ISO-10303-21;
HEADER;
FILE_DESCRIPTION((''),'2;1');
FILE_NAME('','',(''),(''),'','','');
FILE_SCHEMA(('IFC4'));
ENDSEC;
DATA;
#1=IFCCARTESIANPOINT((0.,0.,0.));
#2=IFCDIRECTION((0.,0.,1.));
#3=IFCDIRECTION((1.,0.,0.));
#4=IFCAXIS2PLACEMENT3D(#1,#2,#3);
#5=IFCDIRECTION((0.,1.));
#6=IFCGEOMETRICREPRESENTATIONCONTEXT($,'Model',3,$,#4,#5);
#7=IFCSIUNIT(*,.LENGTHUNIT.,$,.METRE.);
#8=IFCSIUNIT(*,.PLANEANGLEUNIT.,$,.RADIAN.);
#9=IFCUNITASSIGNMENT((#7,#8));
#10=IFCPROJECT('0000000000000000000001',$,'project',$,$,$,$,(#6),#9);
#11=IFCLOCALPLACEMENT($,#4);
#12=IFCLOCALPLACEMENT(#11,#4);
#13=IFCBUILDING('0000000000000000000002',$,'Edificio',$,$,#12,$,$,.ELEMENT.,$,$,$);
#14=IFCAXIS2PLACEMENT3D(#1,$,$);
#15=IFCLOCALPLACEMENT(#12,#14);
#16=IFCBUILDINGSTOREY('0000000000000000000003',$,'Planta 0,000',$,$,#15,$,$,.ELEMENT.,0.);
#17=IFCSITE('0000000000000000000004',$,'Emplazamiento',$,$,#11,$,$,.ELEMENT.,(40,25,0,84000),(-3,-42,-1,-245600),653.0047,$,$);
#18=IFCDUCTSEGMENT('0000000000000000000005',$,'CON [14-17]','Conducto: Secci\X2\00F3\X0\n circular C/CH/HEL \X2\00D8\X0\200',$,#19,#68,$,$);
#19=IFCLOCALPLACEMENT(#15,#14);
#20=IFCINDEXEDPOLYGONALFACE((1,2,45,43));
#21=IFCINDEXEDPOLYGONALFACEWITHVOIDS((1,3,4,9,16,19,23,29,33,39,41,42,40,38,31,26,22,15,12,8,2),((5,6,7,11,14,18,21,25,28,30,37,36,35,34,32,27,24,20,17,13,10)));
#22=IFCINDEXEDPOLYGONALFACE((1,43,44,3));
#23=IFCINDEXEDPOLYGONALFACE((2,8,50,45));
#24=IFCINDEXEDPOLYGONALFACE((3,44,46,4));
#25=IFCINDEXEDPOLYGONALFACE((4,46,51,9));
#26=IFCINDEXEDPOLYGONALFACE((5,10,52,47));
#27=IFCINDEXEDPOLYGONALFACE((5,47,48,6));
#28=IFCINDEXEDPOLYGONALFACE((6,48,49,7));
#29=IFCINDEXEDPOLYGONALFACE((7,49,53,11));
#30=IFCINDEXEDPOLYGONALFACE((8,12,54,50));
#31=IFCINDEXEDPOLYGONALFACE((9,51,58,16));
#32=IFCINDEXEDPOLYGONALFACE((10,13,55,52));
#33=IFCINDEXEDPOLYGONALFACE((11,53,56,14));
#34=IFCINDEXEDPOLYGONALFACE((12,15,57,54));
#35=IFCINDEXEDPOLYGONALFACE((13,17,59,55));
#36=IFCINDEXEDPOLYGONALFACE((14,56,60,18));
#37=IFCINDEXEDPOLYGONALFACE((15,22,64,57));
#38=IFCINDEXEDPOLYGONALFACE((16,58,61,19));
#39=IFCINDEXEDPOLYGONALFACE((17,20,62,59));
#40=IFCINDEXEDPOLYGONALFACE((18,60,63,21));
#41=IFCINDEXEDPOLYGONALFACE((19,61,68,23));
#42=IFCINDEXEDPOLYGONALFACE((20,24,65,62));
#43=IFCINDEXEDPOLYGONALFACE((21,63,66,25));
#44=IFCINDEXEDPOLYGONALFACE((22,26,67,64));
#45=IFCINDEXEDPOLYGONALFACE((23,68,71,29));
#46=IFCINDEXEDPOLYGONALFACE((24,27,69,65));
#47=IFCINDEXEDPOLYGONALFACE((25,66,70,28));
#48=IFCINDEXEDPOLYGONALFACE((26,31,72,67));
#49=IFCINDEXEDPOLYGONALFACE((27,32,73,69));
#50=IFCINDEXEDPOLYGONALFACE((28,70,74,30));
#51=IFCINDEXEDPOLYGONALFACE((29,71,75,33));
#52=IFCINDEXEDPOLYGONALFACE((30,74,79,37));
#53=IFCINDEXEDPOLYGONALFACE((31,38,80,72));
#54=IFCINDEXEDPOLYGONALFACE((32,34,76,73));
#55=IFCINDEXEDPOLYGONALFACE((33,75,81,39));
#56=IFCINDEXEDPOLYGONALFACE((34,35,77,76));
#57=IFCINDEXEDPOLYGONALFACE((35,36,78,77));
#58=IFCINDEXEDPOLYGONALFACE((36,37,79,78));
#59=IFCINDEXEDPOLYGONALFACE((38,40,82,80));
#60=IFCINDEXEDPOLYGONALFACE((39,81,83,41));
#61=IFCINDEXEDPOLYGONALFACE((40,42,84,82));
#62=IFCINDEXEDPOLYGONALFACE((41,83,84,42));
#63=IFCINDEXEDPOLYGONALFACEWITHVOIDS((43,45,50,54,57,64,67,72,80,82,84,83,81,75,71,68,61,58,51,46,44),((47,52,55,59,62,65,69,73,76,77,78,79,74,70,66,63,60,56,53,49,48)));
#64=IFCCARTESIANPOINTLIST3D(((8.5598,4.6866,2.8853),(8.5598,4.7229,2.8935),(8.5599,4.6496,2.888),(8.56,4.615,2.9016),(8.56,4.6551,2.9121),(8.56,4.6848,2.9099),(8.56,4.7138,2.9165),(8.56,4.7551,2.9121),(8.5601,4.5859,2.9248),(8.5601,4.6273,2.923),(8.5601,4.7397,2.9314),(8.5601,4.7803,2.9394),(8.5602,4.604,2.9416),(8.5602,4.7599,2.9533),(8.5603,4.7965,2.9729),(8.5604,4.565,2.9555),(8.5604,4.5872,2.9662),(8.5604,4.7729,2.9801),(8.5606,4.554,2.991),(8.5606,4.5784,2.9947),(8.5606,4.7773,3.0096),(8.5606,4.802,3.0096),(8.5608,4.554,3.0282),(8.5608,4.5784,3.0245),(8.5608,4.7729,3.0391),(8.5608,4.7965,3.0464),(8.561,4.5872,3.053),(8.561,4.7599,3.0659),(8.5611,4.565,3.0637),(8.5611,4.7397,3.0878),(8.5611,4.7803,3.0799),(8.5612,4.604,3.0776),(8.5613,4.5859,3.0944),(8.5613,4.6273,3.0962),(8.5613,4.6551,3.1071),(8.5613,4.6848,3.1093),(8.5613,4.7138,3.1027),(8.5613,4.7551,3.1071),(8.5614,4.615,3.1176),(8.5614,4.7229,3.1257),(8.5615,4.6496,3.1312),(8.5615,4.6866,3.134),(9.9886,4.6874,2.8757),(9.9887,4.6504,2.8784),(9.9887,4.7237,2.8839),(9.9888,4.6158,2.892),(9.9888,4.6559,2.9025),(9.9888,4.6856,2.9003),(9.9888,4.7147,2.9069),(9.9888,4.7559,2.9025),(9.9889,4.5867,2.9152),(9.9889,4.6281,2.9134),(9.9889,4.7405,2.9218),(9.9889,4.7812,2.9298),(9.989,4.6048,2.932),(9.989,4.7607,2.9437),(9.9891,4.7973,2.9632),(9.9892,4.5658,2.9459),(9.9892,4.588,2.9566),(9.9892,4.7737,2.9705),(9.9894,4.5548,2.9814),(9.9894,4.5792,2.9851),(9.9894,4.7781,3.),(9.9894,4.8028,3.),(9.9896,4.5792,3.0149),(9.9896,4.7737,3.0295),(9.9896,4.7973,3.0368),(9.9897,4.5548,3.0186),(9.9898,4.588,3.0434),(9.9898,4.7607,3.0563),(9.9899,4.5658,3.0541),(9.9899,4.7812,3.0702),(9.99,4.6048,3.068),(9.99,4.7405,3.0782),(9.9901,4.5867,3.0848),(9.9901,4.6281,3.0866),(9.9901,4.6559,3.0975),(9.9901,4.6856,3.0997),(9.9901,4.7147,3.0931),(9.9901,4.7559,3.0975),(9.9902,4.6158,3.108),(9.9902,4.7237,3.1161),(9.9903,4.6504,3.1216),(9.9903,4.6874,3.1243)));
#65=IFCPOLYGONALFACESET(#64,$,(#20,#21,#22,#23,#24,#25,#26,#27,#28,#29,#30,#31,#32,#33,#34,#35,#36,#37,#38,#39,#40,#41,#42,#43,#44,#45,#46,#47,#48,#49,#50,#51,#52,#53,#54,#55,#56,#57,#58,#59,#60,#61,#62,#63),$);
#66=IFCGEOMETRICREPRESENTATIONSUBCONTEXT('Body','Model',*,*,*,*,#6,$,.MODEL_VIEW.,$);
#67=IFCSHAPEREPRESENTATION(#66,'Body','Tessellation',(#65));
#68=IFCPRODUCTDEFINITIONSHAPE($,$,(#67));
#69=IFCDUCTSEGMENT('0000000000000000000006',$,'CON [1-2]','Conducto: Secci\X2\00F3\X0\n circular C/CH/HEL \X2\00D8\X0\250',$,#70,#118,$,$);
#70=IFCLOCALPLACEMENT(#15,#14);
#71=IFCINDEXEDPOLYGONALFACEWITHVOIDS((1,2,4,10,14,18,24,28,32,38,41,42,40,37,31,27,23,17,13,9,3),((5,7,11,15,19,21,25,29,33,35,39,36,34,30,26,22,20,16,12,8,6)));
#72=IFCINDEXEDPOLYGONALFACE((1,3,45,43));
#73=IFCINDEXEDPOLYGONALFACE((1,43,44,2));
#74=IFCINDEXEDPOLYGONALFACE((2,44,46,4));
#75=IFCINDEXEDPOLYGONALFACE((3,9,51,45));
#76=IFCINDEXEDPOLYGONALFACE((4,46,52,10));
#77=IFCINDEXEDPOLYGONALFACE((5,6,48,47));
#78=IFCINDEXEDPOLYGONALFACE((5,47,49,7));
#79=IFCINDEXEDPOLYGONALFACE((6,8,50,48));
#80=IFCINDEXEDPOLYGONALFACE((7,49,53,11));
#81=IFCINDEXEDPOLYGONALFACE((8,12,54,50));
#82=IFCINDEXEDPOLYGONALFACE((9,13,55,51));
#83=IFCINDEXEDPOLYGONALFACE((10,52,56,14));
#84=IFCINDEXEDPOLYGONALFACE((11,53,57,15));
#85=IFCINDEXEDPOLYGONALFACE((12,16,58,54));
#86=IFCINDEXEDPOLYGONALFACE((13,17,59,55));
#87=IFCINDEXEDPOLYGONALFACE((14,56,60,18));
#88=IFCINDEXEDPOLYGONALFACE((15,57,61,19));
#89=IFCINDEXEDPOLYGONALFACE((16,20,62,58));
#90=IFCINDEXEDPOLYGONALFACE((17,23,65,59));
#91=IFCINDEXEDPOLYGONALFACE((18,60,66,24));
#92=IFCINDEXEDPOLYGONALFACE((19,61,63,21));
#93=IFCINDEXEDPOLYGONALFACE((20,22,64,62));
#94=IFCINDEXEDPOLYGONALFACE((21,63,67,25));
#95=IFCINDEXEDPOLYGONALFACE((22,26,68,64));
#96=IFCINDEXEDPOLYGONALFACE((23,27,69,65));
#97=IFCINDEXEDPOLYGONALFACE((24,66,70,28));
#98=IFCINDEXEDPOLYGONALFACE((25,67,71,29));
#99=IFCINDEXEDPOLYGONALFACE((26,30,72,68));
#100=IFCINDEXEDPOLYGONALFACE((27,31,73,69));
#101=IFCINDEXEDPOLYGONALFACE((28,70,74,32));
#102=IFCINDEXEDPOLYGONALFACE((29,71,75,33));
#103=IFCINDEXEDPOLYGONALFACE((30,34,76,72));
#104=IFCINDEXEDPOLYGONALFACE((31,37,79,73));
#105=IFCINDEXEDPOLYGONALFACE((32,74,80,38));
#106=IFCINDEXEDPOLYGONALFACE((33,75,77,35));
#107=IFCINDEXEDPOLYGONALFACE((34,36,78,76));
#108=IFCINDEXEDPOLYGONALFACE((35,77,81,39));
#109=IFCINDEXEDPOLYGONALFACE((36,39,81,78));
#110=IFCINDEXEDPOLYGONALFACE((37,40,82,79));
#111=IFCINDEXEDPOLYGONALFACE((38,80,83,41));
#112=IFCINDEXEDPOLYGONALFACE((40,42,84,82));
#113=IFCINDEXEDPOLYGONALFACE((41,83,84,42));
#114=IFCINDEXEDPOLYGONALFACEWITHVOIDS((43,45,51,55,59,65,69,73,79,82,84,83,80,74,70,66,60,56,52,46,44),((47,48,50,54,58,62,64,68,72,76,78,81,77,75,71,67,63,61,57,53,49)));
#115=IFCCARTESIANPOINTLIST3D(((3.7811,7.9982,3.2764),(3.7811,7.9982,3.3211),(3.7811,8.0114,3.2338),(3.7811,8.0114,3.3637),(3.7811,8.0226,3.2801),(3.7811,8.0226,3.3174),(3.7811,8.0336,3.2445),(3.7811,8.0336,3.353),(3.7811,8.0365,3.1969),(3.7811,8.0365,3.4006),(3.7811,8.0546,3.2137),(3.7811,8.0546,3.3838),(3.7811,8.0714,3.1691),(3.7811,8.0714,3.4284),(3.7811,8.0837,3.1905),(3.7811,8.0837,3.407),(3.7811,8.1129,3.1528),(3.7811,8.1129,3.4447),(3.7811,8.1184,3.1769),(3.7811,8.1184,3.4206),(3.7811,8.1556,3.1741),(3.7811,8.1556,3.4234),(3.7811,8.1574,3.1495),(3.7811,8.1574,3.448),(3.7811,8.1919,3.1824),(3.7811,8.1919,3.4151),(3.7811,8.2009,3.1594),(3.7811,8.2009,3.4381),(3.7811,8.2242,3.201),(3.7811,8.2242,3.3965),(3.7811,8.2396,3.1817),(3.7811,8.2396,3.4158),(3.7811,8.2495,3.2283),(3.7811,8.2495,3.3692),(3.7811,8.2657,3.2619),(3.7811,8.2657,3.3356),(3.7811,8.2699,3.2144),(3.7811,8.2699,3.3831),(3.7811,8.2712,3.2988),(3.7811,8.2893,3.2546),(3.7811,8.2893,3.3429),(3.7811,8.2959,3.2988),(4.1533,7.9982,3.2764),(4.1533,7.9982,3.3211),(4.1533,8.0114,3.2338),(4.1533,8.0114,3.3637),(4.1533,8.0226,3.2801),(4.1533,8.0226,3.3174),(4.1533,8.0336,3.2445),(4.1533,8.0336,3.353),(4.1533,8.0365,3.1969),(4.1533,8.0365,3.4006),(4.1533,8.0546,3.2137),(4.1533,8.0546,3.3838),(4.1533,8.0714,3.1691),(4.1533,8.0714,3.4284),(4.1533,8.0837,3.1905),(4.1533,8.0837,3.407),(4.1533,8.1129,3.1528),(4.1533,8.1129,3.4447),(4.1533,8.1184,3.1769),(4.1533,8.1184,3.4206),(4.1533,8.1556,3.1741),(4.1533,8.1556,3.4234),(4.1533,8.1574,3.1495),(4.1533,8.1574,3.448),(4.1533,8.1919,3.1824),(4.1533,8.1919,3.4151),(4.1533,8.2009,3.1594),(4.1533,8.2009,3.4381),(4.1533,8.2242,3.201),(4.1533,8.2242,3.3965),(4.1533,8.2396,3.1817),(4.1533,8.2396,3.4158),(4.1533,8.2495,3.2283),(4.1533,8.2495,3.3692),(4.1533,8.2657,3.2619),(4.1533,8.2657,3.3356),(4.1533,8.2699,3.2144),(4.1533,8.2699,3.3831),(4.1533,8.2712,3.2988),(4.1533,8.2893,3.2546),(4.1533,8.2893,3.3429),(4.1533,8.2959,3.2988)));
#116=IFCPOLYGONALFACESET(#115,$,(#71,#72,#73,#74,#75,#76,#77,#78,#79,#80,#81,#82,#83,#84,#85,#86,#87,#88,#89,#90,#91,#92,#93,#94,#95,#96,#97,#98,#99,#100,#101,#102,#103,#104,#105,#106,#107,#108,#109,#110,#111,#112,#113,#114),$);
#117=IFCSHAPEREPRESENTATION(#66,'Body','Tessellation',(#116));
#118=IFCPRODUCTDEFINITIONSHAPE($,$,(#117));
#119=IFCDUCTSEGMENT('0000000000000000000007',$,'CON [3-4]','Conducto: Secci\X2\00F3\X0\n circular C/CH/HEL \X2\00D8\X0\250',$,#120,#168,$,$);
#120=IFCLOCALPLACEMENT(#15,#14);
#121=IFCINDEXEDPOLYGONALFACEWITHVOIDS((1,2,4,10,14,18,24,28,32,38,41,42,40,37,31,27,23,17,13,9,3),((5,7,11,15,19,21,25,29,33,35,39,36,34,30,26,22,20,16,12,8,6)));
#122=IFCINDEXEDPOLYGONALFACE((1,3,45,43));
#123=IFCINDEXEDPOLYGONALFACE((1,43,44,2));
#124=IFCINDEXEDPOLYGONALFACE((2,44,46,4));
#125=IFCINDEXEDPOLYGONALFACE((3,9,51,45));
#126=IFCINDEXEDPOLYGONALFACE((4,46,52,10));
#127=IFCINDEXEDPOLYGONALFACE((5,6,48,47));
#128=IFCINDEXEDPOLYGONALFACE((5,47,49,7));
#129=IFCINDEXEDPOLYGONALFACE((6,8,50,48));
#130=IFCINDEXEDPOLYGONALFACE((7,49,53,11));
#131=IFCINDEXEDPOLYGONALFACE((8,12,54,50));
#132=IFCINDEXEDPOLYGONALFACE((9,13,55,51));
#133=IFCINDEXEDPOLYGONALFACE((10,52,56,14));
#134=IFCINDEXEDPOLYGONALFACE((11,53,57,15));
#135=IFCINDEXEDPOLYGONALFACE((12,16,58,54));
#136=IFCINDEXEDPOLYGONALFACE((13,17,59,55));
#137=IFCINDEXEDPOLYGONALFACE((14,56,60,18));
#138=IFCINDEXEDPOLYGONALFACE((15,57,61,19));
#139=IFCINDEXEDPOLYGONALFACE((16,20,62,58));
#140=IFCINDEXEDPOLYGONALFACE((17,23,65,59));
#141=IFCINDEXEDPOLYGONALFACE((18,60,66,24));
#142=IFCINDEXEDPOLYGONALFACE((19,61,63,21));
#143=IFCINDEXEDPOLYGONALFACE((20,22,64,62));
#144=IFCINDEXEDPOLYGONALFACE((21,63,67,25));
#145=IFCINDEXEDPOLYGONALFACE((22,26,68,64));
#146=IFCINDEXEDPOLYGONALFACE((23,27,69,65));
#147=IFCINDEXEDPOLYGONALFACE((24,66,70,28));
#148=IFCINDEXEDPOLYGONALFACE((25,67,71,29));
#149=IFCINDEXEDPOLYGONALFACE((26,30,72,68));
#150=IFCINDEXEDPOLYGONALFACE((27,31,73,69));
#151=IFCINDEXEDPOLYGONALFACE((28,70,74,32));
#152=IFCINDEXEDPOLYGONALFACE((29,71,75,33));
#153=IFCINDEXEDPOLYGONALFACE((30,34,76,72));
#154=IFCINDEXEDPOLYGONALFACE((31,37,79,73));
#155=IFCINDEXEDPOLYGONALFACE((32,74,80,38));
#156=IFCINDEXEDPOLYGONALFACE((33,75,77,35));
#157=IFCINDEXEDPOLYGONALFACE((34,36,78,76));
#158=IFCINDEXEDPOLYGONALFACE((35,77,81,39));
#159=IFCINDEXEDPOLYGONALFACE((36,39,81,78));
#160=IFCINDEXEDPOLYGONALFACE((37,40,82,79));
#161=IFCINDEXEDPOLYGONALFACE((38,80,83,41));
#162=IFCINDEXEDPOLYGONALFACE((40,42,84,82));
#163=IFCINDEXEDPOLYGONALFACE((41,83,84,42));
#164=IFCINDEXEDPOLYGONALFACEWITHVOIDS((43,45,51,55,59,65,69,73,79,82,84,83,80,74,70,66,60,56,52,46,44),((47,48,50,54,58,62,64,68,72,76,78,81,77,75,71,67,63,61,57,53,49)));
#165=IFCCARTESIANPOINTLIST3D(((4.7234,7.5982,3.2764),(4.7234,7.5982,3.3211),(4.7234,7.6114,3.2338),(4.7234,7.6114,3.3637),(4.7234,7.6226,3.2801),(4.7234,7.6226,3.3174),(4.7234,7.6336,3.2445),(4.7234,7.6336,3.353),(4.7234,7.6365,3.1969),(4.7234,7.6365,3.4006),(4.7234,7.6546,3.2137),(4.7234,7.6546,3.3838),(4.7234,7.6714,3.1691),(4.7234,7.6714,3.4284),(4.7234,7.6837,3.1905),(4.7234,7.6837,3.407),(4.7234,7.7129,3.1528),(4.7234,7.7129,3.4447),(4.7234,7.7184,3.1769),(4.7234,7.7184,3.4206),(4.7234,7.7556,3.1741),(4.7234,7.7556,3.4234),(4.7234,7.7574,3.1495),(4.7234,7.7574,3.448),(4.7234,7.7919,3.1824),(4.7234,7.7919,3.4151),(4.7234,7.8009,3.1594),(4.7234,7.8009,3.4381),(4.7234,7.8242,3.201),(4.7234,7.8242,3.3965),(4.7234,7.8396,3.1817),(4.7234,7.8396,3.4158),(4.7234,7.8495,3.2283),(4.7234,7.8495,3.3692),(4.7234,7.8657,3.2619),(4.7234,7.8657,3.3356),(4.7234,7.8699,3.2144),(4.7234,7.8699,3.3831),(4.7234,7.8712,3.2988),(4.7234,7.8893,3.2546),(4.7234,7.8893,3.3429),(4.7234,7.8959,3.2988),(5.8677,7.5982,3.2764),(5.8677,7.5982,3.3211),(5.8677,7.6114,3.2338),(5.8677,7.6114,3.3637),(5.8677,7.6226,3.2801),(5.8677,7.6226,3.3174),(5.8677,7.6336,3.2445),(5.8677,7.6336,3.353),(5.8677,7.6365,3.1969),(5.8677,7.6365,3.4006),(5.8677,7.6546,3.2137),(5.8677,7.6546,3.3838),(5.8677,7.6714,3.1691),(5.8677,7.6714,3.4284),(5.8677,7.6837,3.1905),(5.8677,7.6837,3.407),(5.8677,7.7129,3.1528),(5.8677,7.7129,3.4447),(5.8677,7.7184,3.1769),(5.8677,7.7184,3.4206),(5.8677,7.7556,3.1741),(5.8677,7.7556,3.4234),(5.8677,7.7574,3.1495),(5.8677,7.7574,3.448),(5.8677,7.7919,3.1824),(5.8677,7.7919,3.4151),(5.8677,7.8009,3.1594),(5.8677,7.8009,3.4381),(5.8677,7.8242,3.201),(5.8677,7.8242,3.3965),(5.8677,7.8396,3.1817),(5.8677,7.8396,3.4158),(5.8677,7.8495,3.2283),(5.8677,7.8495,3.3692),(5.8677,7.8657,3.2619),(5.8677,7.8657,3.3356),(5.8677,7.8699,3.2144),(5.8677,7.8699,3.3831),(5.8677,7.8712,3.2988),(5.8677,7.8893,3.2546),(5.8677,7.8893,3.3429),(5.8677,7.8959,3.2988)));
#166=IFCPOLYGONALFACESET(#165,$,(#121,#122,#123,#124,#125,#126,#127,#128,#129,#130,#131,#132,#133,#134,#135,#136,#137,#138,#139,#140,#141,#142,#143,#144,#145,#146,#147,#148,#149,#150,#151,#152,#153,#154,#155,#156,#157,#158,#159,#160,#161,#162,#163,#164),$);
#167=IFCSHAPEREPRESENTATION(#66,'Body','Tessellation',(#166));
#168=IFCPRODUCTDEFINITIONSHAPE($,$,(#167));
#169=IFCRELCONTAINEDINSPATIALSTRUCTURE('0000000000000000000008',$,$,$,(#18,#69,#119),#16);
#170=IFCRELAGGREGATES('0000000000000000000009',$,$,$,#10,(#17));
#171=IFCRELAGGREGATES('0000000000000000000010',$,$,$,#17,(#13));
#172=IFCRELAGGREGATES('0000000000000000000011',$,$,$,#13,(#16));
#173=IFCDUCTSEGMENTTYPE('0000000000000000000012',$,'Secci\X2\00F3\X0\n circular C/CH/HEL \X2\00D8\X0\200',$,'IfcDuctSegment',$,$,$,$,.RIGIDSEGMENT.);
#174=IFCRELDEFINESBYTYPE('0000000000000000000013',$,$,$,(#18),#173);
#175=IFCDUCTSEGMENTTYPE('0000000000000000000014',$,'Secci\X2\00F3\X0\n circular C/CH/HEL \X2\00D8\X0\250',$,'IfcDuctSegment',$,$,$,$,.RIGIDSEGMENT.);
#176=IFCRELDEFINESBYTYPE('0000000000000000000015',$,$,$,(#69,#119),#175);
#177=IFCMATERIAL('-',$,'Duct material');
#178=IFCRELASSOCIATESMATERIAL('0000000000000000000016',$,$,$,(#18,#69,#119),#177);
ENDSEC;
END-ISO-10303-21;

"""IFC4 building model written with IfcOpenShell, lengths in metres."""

from ifc_helpers import new_model, si_unit, direction, frame, origin, origin_with_axes, origin_2d_with_axis, place, context, subcontext, project, spatial, hollow_circle, extrude, material, type_object, element, save


model = new_model("IFC4")

# Units and contexts
model_context = context("Model", 3, world=origin_with_axes(), true_north=direction((0.0, 1.0)))
body_context = subcontext(model_context, "Body", "Model", "MODEL_VIEW")
ifc_project = project(units=[si_unit("LENGTHUNIT", "METRE"), si_unit("PLANEANGLEUNIT", "RADIAN")], contexts=[model_context])

# Site, building, storey
site_placement = place(None, origin_with_axes())
site = spatial("IfcSite", under=ifc_project, at=site_placement, Name="Emplazamiento", CompositionType="ELEMENT", RefLatitude=(40, 25, 0, 84000), RefLongitude=(-3, -42, -1, -245600), RefElevation=653.0047)
building_placement = place(site_placement, origin_with_axes())
building = spatial("IfcBuilding", under=site, at=building_placement, Name="Edificio", CompositionType="ELEMENT")
storey_placement = place(building_placement, origin())
storey = spatial("IfcBuildingStorey", under=building, at=storey_placement, Name="Planta 0,000", CompositionType="ELEMENT", Elevation=0.0)

# Shared definitions
ifc_material_1 = material(Name="-", Category="Duct material")

# Duct segments
duct_segment_type_1 = type_object("IfcDuctSegmentType", Name="Sección circular C/CH/HEL Ø200", ApplicableOccurrence="IfcDuctSegment", PredefinedType="RIGIDSEGMENT")
duct_segment_1_placement = place(storey_placement, origin_with_axes())
element("IfcDuctSegment", 1, at=duct_segment_1_placement, inside=storey, type_object=duct_segment_type_1, material=ifc_material_1, Name="CON [14-17]", Description="Conducto: Sección circular C/CH/HEL Ø200", context=body_context, shape_type="SweptSolid", body=[
    extrude(hollow_circle(Radius=0.1247, WallThickness=0.0247, at=origin_2d_with_axis()), frame((8.5607, 4.6773, 3.0096), z_axis=(0.999977, 0.000565, -0.006729), x_axis=(-0.000565, 1.0, 0.0)), (0.0, 0.0, 1.0), 1.4288),
])
duct_segment_type_2 = type_object("IfcDuctSegmentType", Name="Sección circular C/CH/HEL Ø250", ApplicableOccurrence="IfcDuctSegment", PredefinedType="RIGIDSEGMENT")
duct_segment_2_placement = place(storey_placement, origin_with_axes())
element("IfcDuctSegment", 2, at=duct_segment_2_placement, inside=storey, type_object=duct_segment_type_2, material=ifc_material_1, Name="CON [1-2]", Description="Conducto: Sección circular C/CH/HEL Ø250", context=body_context, shape_type="SweptSolid", body=[
    extrude(hollow_circle(Radius=0.1497, WallThickness=0.0247, at=origin_2d_with_axis()), frame((3.7811, 8.1462, 3.2988), z_axis=(1.0, 0.0, 0.0), x_axis=(0.0, 1.0, 0.0)), (0.0, 0.0, 1.0), 0.3722),
])
duct_segment_3_placement = place(storey_placement, origin_with_axes())
element("IfcDuctSegment", 3, at=duct_segment_3_placement, inside=storey, type_object=duct_segment_type_2, material=ifc_material_1, Name="CON [3-4]", Description="Conducto: Sección circular C/CH/HEL Ø250", context=body_context, shape_type="SweptSolid", body=[
    extrude(hollow_circle(Radius=0.1497, WallThickness=0.0247, at=origin_2d_with_axis()), frame((4.7234, 7.7462, 3.2988), z_axis=(1.0, 0.0, 0.0), x_axis=(0.0, 1.0, 0.0)), (0.0, 0.0, 1.0), 1.1443),
])

save(model, "model.ifc")
